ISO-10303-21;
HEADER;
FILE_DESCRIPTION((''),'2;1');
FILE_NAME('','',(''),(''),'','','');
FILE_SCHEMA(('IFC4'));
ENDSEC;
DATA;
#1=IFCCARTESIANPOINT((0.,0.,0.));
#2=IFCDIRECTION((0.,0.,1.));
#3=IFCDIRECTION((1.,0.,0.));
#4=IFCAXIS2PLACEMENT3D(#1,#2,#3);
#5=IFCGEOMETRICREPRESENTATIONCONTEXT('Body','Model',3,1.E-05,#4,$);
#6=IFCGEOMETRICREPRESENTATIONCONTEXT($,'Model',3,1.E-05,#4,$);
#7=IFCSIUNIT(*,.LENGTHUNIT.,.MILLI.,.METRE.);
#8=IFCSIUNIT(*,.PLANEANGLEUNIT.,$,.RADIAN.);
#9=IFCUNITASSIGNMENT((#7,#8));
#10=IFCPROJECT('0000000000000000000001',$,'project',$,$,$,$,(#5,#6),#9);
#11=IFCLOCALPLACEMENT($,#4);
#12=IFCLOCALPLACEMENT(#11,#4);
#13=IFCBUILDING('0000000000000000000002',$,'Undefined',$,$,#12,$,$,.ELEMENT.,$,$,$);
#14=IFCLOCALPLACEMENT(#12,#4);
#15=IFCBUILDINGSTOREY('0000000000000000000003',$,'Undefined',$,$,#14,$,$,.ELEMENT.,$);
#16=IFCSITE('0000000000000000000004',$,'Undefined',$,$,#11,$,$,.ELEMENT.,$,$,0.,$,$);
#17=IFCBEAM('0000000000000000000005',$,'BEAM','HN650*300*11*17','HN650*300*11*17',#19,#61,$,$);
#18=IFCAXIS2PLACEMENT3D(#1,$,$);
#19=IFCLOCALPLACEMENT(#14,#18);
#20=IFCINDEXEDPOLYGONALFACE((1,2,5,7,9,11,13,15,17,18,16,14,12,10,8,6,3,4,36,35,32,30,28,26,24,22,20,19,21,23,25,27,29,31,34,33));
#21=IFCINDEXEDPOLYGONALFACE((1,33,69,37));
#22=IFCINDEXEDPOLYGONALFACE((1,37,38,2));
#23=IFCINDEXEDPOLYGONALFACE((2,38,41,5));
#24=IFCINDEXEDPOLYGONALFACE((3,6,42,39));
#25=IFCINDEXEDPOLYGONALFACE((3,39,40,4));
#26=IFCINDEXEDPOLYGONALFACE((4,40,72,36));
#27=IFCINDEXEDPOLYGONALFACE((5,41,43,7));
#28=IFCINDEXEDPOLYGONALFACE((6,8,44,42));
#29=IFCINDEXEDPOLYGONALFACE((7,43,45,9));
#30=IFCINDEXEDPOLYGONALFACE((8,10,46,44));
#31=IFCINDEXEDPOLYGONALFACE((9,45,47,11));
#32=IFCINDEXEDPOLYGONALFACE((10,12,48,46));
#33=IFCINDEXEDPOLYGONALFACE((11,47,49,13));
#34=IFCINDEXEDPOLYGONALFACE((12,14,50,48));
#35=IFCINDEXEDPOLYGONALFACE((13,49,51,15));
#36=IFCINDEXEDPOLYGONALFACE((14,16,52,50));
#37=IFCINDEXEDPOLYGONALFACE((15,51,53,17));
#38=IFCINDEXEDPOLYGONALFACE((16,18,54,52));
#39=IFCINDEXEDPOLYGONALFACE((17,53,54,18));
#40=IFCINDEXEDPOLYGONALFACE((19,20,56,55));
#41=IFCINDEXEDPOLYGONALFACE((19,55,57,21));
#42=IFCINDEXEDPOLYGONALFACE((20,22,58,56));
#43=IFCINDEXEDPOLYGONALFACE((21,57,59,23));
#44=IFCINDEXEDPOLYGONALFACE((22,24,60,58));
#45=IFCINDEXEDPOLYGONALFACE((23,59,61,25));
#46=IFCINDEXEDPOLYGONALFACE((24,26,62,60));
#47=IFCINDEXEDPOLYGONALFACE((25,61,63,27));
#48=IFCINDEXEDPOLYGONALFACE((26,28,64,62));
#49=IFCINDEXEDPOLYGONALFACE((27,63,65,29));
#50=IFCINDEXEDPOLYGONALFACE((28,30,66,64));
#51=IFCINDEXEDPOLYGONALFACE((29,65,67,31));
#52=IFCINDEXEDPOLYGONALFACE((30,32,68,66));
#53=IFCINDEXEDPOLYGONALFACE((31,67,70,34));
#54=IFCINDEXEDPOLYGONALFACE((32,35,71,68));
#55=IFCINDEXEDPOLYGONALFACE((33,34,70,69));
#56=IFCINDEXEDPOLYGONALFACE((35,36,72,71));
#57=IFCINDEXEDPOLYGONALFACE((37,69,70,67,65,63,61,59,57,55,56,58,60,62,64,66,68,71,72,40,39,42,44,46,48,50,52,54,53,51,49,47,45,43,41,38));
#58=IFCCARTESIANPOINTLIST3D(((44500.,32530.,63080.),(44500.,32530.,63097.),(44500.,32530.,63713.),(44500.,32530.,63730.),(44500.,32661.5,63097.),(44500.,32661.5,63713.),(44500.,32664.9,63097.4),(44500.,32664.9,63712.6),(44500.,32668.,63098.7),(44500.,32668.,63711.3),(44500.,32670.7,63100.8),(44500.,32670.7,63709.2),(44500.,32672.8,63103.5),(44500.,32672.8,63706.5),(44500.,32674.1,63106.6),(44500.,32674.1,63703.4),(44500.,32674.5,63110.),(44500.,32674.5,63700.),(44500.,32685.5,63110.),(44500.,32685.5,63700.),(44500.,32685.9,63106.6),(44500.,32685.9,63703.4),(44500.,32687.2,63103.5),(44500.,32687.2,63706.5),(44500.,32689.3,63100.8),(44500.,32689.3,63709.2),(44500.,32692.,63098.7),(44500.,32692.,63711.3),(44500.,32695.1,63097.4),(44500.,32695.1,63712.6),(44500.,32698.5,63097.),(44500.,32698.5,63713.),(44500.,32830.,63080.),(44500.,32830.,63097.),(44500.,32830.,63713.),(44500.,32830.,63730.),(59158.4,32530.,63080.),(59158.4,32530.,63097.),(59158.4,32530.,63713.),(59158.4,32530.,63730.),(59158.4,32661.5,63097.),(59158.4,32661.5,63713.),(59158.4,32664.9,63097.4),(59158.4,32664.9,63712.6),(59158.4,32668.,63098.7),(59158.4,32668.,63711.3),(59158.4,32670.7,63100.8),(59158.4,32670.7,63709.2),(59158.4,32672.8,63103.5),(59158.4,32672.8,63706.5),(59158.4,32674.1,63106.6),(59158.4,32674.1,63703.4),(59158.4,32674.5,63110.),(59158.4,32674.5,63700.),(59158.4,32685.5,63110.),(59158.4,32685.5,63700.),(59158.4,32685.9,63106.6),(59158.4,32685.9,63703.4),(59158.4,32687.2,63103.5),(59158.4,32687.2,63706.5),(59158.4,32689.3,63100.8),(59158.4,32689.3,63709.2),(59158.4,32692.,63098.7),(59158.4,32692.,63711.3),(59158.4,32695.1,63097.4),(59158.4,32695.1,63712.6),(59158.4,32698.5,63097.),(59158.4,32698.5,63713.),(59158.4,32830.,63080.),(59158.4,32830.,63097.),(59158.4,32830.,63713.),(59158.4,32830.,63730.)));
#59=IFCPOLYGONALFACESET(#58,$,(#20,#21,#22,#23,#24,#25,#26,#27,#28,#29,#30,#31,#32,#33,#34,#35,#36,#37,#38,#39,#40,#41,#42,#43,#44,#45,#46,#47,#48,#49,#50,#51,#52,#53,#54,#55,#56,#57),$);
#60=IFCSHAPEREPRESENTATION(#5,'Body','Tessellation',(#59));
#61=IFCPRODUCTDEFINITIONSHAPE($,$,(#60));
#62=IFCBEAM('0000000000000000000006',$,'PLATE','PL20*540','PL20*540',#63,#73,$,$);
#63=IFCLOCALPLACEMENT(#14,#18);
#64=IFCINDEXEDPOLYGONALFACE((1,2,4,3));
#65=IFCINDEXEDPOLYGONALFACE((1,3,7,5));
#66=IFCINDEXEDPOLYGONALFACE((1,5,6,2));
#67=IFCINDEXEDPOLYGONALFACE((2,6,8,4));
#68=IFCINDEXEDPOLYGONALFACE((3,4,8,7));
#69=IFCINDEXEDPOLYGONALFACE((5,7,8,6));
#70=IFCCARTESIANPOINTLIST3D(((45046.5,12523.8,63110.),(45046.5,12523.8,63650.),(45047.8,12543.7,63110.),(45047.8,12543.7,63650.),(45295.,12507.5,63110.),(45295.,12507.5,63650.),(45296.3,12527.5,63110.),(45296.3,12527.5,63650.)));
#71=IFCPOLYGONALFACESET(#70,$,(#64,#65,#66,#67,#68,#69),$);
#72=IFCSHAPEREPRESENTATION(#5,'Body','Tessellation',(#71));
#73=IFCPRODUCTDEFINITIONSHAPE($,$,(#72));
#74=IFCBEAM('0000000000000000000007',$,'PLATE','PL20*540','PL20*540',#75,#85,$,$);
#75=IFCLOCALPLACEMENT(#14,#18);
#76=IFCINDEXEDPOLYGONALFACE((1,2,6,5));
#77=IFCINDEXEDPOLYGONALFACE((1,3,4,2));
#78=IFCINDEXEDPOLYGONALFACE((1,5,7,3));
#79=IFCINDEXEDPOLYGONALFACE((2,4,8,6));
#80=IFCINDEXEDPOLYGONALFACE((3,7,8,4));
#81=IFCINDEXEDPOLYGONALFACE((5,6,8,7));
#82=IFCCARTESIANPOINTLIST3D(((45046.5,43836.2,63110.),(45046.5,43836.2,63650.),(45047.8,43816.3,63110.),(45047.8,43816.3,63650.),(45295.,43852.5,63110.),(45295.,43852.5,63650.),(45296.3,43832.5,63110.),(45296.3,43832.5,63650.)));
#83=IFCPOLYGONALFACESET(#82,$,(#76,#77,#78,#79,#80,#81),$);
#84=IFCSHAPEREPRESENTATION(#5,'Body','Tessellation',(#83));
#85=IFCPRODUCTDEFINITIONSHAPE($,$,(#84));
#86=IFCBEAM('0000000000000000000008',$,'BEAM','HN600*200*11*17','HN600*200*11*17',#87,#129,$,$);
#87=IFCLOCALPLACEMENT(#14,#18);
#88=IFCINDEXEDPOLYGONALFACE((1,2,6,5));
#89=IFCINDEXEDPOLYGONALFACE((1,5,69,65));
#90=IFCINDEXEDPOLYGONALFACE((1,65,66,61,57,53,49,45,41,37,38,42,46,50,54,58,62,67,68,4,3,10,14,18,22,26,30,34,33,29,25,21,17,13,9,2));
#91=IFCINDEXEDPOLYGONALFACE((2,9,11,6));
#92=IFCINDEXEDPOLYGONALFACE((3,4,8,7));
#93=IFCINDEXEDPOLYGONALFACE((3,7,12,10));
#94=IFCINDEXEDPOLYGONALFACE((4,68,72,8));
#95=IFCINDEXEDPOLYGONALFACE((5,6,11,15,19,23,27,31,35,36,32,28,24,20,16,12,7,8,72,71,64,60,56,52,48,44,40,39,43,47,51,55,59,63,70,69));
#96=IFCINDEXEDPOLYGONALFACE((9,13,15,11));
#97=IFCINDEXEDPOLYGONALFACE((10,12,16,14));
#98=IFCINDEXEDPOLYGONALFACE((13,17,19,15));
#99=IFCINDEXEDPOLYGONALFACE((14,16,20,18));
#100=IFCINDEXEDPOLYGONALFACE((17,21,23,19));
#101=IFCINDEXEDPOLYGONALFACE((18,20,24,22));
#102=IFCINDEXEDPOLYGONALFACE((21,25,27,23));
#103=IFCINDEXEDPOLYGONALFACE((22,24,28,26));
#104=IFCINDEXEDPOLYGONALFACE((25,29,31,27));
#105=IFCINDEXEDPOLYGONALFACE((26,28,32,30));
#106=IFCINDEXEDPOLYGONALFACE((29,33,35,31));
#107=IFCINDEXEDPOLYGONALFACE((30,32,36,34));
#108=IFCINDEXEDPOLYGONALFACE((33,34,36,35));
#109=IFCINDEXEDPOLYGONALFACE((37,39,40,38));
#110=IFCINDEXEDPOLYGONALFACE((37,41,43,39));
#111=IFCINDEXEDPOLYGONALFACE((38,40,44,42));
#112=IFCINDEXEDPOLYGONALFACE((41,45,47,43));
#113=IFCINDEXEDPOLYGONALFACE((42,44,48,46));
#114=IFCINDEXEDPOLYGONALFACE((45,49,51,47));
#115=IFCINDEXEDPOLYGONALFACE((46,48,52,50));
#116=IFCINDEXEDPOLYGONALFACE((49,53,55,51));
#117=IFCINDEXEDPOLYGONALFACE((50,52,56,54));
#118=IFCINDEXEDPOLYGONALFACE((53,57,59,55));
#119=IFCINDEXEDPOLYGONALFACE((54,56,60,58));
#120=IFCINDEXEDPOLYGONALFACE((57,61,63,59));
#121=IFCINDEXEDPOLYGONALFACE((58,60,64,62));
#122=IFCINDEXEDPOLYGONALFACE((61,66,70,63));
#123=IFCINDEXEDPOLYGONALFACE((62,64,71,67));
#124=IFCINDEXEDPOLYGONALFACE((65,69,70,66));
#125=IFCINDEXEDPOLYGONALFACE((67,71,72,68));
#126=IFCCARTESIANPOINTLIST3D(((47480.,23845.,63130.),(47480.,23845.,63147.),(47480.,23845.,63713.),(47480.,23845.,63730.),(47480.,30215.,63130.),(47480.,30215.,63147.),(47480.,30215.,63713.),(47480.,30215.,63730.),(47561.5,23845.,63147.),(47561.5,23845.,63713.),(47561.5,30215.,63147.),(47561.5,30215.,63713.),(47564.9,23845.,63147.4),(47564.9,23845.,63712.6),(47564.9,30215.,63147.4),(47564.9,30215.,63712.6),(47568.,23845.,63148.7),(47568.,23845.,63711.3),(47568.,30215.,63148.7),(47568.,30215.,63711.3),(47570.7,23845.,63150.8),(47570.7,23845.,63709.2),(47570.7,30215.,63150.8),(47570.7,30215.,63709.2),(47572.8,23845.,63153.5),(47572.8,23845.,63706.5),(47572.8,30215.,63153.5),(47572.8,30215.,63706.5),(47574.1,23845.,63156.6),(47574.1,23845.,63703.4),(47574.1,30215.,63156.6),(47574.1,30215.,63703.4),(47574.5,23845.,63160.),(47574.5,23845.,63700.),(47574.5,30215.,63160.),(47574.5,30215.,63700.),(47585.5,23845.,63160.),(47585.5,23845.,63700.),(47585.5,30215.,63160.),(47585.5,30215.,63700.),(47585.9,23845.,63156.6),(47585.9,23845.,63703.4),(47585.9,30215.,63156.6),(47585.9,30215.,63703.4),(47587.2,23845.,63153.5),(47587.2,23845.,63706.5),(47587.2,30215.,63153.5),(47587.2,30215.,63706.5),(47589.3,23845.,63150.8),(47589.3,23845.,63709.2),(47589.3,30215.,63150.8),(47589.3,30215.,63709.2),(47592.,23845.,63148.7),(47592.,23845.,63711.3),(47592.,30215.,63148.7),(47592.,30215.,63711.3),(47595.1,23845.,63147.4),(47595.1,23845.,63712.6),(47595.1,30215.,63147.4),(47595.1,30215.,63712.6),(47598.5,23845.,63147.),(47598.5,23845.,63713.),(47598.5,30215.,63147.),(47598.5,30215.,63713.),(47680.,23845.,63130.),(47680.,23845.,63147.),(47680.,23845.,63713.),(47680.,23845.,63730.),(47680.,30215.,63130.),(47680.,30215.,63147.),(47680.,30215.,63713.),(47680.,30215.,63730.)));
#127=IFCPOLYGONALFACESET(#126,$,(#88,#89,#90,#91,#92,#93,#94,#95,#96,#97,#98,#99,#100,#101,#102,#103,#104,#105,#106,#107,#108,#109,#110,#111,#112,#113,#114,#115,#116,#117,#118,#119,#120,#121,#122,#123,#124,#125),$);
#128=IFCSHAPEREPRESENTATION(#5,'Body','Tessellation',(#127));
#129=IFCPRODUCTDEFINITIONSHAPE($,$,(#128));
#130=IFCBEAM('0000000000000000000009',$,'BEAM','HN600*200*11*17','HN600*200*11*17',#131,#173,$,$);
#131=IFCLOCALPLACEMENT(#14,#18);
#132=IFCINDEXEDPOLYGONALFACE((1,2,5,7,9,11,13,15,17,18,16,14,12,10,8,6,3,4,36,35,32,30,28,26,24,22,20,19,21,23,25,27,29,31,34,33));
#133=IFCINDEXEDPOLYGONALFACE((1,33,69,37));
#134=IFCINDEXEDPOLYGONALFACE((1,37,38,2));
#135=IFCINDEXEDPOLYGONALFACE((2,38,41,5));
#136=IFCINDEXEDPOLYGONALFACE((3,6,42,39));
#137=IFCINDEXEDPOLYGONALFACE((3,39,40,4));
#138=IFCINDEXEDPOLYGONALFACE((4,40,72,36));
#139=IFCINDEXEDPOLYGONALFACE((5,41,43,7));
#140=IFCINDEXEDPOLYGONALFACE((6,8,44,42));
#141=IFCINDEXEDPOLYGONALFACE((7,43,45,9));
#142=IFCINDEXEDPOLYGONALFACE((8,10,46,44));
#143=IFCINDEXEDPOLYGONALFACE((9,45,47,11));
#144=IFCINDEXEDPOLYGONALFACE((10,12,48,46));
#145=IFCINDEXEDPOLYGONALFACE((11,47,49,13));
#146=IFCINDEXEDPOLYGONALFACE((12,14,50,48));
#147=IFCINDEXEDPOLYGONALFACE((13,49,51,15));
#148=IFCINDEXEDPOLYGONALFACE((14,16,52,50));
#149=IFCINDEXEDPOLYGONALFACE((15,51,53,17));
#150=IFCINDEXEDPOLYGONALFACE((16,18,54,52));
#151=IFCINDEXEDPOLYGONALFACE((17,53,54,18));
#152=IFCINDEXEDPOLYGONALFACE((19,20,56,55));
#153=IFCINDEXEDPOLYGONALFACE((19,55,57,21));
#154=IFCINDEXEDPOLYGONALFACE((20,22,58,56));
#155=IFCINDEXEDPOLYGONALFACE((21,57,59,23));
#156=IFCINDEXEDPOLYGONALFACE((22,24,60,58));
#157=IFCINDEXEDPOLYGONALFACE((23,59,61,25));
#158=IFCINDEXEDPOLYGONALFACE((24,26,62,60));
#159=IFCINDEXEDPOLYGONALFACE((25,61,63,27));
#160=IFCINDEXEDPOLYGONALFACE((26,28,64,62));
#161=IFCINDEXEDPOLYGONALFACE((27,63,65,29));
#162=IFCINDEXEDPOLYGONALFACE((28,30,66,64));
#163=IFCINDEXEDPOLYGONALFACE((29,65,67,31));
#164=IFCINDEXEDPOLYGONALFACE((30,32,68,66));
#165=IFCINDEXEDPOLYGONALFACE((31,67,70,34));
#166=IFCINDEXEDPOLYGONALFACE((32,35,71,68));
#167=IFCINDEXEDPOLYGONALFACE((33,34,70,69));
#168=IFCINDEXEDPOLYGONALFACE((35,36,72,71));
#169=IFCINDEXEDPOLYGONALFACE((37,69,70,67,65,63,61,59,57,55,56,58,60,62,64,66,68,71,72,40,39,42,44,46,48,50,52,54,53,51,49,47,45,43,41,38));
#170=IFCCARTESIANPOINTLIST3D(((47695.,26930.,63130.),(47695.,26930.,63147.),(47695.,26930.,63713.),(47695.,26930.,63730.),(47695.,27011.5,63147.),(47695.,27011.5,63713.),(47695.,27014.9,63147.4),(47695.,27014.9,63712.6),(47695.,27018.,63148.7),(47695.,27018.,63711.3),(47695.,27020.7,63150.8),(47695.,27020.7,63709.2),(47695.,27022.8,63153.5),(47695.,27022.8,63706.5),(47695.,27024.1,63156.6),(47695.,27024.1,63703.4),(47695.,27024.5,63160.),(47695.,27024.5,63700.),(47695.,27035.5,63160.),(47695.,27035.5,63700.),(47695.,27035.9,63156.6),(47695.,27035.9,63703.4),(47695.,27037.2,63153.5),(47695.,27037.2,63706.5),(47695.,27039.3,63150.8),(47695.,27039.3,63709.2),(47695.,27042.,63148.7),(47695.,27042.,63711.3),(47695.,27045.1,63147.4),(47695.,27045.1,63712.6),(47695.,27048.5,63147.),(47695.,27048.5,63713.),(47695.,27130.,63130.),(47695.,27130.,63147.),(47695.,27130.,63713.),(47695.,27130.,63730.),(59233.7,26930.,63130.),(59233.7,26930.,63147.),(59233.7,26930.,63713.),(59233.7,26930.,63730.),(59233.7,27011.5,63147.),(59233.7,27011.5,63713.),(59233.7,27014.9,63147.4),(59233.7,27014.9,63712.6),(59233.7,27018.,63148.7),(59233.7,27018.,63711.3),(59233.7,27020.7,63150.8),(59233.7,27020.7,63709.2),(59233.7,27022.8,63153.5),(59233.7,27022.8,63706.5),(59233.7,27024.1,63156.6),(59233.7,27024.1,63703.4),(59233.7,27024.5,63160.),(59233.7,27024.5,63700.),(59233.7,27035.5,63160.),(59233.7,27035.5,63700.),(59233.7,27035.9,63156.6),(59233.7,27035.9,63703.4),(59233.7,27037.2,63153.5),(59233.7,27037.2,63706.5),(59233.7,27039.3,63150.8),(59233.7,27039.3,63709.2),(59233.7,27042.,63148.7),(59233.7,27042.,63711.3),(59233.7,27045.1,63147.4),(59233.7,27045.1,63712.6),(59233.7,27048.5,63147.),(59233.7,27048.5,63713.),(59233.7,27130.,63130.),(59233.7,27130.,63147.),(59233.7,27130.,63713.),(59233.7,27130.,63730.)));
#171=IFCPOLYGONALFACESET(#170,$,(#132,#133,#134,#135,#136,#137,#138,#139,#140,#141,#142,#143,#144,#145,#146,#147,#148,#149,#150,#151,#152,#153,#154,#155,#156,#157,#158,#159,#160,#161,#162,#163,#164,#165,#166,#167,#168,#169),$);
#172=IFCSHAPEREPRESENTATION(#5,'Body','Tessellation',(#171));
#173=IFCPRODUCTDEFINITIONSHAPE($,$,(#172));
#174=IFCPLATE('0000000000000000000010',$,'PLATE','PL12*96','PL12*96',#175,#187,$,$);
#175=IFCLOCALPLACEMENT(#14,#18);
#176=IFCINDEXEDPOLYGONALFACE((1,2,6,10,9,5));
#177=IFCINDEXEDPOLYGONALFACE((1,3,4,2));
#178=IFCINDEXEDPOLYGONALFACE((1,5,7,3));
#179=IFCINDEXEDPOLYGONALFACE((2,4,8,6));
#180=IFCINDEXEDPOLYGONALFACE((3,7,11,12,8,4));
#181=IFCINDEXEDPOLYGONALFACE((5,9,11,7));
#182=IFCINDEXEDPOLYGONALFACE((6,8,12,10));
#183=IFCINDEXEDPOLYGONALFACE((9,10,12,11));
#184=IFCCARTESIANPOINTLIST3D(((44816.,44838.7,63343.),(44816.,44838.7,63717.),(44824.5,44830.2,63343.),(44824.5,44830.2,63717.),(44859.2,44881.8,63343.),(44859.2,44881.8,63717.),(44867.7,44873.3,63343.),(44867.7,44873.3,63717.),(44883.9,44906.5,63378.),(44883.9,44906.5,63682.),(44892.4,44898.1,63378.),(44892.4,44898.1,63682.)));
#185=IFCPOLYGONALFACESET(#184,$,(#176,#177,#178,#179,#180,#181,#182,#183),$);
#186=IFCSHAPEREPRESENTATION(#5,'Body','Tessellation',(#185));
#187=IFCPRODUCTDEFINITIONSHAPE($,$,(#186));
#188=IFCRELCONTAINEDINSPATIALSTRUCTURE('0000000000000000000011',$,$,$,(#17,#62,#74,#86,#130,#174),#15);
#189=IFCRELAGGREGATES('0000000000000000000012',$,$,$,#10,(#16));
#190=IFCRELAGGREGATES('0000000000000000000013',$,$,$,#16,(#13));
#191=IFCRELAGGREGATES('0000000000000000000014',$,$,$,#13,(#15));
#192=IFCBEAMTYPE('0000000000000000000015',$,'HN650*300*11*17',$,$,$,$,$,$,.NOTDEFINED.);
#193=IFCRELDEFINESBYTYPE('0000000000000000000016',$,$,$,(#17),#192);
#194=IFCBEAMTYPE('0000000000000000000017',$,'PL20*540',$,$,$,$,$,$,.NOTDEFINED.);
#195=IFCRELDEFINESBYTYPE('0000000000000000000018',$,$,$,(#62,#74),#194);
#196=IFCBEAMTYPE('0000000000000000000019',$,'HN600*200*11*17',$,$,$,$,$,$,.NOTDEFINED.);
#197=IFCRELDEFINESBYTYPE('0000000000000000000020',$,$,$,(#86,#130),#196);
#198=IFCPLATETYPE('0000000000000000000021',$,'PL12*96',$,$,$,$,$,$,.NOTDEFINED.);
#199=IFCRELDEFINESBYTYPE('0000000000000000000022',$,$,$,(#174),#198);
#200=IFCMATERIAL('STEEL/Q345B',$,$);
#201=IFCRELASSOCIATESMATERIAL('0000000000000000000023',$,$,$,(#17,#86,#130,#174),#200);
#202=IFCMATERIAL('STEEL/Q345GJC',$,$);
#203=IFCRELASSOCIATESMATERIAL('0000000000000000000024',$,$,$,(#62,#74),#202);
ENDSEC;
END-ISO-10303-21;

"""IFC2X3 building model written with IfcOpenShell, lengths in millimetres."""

from ifc_helpers import new_model, si_unit, frame, origin_with_axes, origin_2d_with_axis, place, context, project, spatial, polyline, rectangle, i_section, outline, extrude, material, type_object, element, save


model = new_model("IFC2X3")

# Units and contexts
model_context_1 = context("Model", 3, precision=1e-05, world=origin_with_axes(), identifier="Body")
model_context_2 = context("Model", 3, precision=1e-05, world=origin_with_axes())
ifc_project = project(units=[si_unit("LENGTHUNIT", "METRE", prefix="MILLI"), si_unit("PLANEANGLEUNIT", "RADIAN")], contexts=[model_context_1, model_context_2])

# Site, building, storey
site_placement = place(None, origin_with_axes())
site = spatial("IfcSite", under=ifc_project, at=site_placement, Name="Undefined", CompositionType="ELEMENT", RefElevation=0.0)
building_placement = place(site_placement, origin_with_axes())
building = spatial("IfcBuilding", under=site, at=building_placement, Name="Undefined", CompositionType="ELEMENT")
storey_placement = place(building_placement, origin_with_axes())
storey = spatial("IfcBuildingStorey", under=building, at=storey_placement, Name="Undefined", CompositionType="ELEMENT")

# Beams
ifc_material_1 = material(Name="STEEL/Q345B")
beam_type_1 = type_object("IfcBeamType", Name="HN650*300*11*17", PredefinedType="NOTDEFINED")
beam_1_placement = place(storey_placement, frame((44480.0, 32680.0, 63405.0), z_axis=(0.0, 0.0, 1.0), x_axis=(1.0, 0.0, 0.0)))
element("IfcBeam", 1, at=beam_1_placement, inside=storey, type_object=beam_type_1, material=ifc_material_1, Name="BEAM", Description="HN650*300*11*17", ObjectType="HN650*300*11*17", context=model_context_1, shape_type="SweptSolid", body=[
    extrude(i_section(OverallWidth=300.0, OverallDepth=650.0, WebThickness=11.0, FlangeThickness=17.0, FilletRadius=13.0, at=origin_2d_with_axis()), frame((14678.4, 0.0, 0.0), z_axis=(-1.0, 0.0, 0.0), x_axis=(0.0, -1.0, 0.0)), (0.0, 0.0, 1.0), 14658.4),
])
ifc_material_2 = material(Name="STEEL/Q345GJC")
beam_type_2 = type_object("IfcBeamType", Name="PL20*540", PredefinedType="NOTDEFINED")
for number, where, z_axis, x_axis, name in (
    (2, (45047.2, 12533.7, 63380.0), (0.0, 0.0, 1.0), (0.997873, -0.065183, 0.0), "PLATE"),
    (3, (45047.2, 43826.3, 63380.0), (0.0, 0.0, 1.0), (0.997873, 0.065184, 0.0), "PLATE"),
):
    element("IfcBeam", number, at=place(storey_placement, frame(where, z_axis=z_axis, x_axis=x_axis)), inside=storey, type_object=beam_type_2, material=ifc_material_2, Name=name, Description="PL20*540", ObjectType="PL20*540", context=model_context_1, shape_type="SweptSolid", body=[
        extrude(rectangle(XDim=20.0, YDim=540.0, at=origin_2d_with_axis()), frame((249.0, 0.0, 0.0), z_axis=(-1.0, 0.0, 0.0), x_axis=(0.0, -1.0, 0.0)), (0.0, 0.0, 1.0), 249.0),
    ])
beam_type_3 = type_object("IfcBeamType", Name="HN600*200*11*17", PredefinedType="NOTDEFINED")
beam_2_placement = place(storey_placement, frame((47580.0, 23680.0, 63430.0), z_axis=(0.0, 0.0, 1.0), x_axis=(0.0, 1.0, 0.0)))
element("IfcBeam", 4, at=beam_2_placement, inside=storey, type_object=beam_type_3, material=ifc_material_1, Name="BEAM", Description="HN600*200*11*17", ObjectType="HN600*200*11*17", context=model_context_1, shape_type="SweptSolid", body=[
    extrude(i_section(OverallWidth=200.0, OverallDepth=600.0, WebThickness=11.0, FlangeThickness=17.0, FilletRadius=13.0, at=origin_2d_with_axis()), frame((6535.0, 0.0, 0.0), z_axis=(-1.0, 0.0, 0.0), x_axis=(0.0, -1.0, 0.0)), (0.0, 0.0, 1.0), 6370.0),
])
beam_3_placement = place(storey_placement, frame((47580.0, 27030.0, 63430.0), z_axis=(0.0, 0.0, 1.0), x_axis=(1.0, 0.0, 0.0)))
element("IfcBeam", 5, at=beam_3_placement, inside=storey, type_object=beam_type_3, material=ifc_material_1, Name="BEAM", Description="HN600*200*11*17", ObjectType="HN600*200*11*17", context=model_context_1, shape_type="SweptSolid", body=[
    extrude(i_section(OverallWidth=200.0, OverallDepth=600.0, WebThickness=11.0, FlangeThickness=17.0, FilletRadius=13.0, at=origin_2d_with_axis()), frame((11653.7, 0.0, 0.0), z_axis=(-1.0, 0.0, 0.0), x_axis=(0.0, -1.0, 0.0)), (0.0, 0.0, 1.0), 11538.7),
])

# Plate
plate_type_1 = type_object("IfcPlateType", Name="PL12*96", PredefinedType="NOTDEFINED")
plate_1_placement = place(storey_placement, frame((44888.2, 44902.3, 63343.0), z_axis=(-0.707107, 0.707107, 0.0), x_axis=(-0.707107, -0.707107, 0.0)))
element("IfcPlate", 6, at=plate_1_placement, inside=storey, type_object=plate_type_1, material=ifc_material_1, Name="PLATE", Description="PL12*96", ObjectType="PL12*96", context=model_context_1, shape_type="SweptSolid", body=[
    extrude(outline(polyline([(0.0, 35.0), (35.0, 0.0), (96.0, 0.0), (96.0, 374.0), (35.0, 374.0), (0.0, 339.0), (0.0, 35.0)])), frame((0.0, 0.0, -6.0), z_axis=(0.0, 0.0, 1.0), x_axis=(1.0, 0.0, 0.0)), (0.0, 0.0, 1.0), 12.0),
])

save(model, "model.ifc")
